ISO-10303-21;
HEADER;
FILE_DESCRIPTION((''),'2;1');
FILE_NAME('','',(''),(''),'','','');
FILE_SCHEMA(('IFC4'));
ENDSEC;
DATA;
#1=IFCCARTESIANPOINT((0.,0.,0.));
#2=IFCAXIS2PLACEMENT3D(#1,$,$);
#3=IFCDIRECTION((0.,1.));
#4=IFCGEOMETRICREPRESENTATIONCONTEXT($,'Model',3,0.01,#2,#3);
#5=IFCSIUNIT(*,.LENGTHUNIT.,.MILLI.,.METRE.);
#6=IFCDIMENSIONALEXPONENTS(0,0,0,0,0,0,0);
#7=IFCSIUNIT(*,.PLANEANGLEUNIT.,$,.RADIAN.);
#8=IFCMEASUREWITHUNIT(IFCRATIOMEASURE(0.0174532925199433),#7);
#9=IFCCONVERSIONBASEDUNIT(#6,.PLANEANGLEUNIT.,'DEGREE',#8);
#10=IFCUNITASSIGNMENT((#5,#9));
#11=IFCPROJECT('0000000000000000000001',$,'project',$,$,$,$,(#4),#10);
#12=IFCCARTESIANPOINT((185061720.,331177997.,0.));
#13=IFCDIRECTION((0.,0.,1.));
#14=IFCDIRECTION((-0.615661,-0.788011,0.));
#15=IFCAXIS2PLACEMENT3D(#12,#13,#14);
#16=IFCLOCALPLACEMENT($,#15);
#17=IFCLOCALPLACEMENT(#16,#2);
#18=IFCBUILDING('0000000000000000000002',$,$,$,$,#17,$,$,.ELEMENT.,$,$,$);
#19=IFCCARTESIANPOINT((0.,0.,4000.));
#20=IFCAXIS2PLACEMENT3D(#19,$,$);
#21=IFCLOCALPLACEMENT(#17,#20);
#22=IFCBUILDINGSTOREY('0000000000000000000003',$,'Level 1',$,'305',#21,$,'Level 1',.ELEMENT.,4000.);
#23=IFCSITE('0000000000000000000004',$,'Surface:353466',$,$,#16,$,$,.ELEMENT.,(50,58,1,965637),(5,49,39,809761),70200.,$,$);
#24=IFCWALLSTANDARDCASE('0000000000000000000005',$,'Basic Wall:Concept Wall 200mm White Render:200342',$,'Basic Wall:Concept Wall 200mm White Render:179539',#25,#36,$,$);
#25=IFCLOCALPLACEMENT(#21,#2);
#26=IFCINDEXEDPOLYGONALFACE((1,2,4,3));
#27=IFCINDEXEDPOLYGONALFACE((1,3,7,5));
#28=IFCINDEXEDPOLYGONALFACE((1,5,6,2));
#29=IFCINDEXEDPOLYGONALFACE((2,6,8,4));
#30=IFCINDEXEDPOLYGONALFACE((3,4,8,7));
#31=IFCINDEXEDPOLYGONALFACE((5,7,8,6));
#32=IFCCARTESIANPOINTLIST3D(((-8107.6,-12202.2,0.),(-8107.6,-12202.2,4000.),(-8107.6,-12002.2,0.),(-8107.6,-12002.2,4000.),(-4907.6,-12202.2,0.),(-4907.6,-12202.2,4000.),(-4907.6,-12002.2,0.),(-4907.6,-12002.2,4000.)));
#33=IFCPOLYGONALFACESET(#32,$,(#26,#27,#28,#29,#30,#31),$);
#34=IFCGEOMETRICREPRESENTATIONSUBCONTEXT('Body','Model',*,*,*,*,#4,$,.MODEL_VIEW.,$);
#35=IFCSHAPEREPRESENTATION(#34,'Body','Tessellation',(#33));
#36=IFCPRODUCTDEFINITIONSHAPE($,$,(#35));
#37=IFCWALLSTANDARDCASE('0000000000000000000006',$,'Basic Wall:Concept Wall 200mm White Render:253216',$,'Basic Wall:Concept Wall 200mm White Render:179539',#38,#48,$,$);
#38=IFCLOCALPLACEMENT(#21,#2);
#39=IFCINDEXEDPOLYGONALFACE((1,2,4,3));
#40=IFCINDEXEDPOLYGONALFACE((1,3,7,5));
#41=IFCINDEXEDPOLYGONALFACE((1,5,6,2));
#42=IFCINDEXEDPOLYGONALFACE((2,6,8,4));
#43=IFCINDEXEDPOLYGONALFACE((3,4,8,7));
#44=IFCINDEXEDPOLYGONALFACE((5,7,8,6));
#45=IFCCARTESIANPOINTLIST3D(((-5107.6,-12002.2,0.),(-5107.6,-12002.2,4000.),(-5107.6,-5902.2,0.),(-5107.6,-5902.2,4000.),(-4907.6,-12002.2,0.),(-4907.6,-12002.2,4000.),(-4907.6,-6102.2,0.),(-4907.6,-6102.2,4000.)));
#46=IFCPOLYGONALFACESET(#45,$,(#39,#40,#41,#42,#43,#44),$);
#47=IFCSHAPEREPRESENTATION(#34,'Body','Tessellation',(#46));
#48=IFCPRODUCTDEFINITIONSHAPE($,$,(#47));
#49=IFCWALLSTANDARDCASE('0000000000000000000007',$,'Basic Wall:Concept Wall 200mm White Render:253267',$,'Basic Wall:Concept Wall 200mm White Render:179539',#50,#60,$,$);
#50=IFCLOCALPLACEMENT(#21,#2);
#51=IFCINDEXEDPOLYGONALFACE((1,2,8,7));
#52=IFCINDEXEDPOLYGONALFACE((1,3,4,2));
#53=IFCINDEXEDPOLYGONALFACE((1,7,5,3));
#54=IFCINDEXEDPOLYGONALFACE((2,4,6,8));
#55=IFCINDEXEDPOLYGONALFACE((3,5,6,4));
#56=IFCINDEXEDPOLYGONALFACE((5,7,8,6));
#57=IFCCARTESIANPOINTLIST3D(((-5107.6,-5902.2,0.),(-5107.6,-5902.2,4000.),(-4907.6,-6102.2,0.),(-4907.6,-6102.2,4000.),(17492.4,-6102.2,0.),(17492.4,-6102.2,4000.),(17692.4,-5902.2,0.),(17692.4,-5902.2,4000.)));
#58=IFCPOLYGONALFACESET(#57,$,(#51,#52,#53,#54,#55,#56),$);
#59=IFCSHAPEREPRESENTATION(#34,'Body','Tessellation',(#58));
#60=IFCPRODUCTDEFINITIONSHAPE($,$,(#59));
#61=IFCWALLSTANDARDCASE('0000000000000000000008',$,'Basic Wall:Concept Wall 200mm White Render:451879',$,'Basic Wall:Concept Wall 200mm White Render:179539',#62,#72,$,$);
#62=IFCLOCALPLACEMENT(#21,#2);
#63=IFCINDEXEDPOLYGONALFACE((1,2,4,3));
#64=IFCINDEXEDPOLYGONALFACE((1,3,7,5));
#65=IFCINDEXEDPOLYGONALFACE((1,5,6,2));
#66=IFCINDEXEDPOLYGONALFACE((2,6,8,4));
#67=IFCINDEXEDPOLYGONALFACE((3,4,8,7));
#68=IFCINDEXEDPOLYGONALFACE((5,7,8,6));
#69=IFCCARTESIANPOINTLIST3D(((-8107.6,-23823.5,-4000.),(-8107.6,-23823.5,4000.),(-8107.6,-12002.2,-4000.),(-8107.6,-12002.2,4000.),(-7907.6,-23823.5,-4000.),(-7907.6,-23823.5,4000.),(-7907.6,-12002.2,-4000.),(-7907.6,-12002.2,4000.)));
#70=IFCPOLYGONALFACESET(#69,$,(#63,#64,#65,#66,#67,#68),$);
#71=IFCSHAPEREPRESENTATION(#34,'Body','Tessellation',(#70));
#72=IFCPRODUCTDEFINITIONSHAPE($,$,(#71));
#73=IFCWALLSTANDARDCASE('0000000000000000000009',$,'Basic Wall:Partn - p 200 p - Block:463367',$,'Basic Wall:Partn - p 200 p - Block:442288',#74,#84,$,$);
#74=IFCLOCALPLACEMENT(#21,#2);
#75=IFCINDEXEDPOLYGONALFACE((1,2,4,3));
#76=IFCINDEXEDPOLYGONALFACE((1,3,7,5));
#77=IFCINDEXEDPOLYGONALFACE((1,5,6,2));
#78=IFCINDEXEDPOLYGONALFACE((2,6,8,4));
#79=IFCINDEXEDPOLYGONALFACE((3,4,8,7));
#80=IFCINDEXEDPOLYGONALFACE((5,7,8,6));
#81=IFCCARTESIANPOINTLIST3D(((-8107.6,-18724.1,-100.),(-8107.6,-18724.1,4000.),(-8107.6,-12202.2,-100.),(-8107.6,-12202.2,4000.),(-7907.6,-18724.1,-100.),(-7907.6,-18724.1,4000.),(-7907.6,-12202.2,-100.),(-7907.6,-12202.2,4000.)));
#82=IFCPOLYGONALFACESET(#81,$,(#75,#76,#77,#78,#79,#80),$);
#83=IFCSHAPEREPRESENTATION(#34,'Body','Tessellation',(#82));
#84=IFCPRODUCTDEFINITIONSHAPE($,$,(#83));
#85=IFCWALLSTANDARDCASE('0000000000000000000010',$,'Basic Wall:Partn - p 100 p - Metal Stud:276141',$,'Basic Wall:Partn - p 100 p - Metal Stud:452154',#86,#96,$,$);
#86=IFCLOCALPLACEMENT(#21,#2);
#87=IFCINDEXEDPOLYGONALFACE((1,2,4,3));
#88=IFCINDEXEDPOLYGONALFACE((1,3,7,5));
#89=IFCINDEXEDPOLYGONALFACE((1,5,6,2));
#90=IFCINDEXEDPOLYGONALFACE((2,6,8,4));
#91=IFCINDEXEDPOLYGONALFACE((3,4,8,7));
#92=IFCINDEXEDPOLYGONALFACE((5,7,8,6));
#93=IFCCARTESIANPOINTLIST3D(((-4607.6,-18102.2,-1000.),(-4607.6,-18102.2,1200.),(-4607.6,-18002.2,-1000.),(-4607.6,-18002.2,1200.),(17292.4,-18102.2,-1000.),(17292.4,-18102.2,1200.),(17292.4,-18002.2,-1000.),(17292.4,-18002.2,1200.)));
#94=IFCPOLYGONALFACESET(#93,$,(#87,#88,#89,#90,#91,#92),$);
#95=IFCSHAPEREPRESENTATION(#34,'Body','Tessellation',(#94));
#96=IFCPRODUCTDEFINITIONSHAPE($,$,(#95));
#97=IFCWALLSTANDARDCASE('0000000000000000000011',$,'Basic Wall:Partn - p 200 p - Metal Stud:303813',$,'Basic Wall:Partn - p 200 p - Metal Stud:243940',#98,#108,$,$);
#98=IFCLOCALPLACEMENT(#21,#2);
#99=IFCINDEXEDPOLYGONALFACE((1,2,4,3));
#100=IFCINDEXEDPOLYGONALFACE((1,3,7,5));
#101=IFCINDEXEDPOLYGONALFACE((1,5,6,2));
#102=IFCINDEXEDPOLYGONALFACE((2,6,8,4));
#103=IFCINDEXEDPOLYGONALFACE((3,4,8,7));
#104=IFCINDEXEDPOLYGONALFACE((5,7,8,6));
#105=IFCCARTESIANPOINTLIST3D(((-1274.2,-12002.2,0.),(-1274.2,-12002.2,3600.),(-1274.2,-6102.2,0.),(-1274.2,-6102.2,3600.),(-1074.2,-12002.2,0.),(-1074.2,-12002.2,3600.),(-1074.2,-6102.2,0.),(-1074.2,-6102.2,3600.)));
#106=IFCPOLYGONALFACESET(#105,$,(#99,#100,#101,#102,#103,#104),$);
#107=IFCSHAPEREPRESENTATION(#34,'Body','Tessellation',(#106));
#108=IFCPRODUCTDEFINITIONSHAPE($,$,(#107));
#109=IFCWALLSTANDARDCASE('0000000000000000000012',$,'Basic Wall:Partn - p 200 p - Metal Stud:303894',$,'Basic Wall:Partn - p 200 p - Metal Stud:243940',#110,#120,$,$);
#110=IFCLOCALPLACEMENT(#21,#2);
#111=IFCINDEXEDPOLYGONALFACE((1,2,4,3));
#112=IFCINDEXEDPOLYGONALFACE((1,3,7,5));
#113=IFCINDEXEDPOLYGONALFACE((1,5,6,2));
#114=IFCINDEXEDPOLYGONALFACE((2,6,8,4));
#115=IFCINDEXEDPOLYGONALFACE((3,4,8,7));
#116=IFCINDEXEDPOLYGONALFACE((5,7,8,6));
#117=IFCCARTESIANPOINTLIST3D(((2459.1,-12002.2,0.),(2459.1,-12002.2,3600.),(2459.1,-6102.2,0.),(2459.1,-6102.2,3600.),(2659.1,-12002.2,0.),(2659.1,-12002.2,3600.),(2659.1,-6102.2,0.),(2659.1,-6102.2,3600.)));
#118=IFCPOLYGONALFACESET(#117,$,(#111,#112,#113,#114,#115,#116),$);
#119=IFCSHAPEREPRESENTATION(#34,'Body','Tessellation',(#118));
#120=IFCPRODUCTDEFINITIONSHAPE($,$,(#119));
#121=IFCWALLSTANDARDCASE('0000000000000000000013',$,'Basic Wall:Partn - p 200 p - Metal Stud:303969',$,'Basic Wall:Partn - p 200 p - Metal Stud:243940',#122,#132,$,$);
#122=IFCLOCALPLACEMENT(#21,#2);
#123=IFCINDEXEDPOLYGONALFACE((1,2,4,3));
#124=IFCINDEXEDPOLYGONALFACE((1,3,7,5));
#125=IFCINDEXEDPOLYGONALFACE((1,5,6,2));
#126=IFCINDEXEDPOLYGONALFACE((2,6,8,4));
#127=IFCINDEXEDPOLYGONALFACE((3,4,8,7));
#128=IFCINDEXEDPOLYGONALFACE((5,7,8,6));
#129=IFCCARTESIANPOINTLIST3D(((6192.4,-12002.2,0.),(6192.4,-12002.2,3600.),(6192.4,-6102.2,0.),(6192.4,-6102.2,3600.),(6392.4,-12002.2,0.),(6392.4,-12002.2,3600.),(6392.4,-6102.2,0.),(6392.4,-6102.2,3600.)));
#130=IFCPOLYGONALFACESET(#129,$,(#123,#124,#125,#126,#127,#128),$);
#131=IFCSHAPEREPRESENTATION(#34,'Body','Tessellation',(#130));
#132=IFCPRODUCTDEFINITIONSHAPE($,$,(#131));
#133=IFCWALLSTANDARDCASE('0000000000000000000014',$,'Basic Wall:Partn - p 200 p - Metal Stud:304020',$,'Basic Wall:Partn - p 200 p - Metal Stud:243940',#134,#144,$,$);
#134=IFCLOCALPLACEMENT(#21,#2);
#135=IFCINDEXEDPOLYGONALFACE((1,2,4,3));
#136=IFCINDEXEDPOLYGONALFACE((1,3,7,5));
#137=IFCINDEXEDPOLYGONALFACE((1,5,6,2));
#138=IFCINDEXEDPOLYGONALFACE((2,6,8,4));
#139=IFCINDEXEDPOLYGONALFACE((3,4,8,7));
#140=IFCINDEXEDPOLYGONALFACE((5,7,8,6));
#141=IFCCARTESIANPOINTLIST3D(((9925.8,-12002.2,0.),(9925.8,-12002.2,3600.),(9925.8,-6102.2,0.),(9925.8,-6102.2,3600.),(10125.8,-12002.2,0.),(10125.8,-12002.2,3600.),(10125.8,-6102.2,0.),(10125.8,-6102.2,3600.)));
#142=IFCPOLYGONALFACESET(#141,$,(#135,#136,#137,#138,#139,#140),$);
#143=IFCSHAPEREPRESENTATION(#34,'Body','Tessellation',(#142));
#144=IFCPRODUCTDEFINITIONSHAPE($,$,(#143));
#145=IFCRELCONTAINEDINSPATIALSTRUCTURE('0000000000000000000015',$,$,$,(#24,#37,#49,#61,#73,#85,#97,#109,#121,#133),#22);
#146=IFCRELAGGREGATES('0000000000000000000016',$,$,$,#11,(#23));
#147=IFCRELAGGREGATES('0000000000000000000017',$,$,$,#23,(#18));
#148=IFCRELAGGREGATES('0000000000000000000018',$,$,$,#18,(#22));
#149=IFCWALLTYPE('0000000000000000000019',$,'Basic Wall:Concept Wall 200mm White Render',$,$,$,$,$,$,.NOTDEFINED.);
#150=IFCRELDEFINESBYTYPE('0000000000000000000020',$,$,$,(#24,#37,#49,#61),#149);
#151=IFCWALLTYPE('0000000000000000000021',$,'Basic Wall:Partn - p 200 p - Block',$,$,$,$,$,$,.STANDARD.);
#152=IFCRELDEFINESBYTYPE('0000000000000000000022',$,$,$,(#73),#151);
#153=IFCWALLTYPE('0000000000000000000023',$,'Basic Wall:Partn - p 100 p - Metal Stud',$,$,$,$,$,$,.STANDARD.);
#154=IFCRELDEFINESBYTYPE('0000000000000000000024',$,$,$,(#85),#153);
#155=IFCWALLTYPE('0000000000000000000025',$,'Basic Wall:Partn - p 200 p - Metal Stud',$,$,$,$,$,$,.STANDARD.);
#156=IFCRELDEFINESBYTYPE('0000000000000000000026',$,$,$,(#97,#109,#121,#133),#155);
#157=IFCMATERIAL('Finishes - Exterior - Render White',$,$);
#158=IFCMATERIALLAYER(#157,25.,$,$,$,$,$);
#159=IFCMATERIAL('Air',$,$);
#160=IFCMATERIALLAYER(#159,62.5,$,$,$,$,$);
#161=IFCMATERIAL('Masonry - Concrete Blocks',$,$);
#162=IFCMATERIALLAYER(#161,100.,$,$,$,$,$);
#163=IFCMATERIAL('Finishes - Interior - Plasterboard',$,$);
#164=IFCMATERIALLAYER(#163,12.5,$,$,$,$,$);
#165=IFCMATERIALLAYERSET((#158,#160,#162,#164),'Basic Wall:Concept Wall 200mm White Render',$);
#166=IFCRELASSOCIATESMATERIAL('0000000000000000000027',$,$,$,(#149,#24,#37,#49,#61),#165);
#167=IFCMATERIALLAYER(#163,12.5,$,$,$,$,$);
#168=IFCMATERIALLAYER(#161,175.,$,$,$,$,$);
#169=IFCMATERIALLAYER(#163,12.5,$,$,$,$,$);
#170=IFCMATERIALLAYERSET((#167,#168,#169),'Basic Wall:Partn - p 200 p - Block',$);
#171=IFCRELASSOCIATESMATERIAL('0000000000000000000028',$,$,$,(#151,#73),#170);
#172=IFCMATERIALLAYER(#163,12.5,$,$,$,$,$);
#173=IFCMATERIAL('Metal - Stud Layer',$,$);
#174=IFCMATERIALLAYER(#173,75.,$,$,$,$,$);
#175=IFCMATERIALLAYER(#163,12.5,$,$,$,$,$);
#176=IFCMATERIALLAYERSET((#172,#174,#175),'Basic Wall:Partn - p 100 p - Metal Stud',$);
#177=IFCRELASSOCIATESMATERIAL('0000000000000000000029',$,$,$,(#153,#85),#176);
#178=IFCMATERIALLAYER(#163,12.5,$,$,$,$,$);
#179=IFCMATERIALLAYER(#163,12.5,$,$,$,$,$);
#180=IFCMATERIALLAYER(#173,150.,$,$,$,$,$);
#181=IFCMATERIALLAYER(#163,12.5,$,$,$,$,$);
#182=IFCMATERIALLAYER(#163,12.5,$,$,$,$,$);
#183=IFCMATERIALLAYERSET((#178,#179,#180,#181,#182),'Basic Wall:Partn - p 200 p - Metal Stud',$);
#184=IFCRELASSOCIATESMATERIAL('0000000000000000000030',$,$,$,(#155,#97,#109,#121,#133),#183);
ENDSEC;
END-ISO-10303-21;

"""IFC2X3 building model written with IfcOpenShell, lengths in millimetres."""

from ifc_helpers import new_model, entity, si_unit, converted_unit, direction, frame, frame_2d, origin, place, context, subcontext, project, spatial, polyline, rectangle, outline, extrude, clip, halfspace, bounded_halfspace, material, layer, layer_set, layer_usage, type_object, element, save


model = new_model("IFC2X3")

# Units and contexts
model_context = context("Model", 3, precision=0.01, world=origin(), true_north=direction((0.0, 1.0)))
body_context = subcontext(model_context, "Body", "Model", "MODEL_VIEW")
ifc_project = project(units=[si_unit("LENGTHUNIT", "METRE", prefix="MILLI"), converted_unit("PLANEANGLEUNIT", "DEGREE", entity("IfcRatioMeasure", 0.0174532925199433), si_unit("PLANEANGLEUNIT", "RADIAN"), dimensions=[0, 0, 0, 0, 0, 0, 0])], contexts=[model_context])

# Site, building, storey
site_placement = place(None, frame((185061720.0, 331177997.0, 0.0), z_axis=(0.0, 0.0, 1.0), x_axis=(-0.615661, -0.788011, 0.0)))
site = spatial("IfcSite", under=ifc_project, at=site_placement, Name="Surface:353466", CompositionType="ELEMENT", RefLatitude=(50, 58, 1, 965637), RefLongitude=(5, 49, 39, 809761), RefElevation=70200.0)
building_placement = place(site_placement, origin())
building = spatial("IfcBuilding", under=site, at=building_placement, CompositionType="ELEMENT")
storey_placement = place(building_placement, frame((0.0, 0.0, 4000.0)))
storey = spatial("IfcBuildingStorey", under=building, at=storey_placement, Name="Level 1", ObjectType="305", LongName="Level 1", CompositionType="ELEMENT", Elevation=4000.0)

# Walls
ifc_material_1 = material(Name="Finishes - Exterior - Render White")
ifc_layer_1 = layer(ifc_material_1, 25.0)
ifc_material_2 = material(Name="Air")
ifc_layer_2 = layer(ifc_material_2, 62.5)
ifc_material_3 = material(Name="Masonry - Concrete Blocks")
ifc_layer_3 = layer(ifc_material_3, 100.0)
ifc_material_4 = material(Name="Finishes - Interior - Plasterboard")
ifc_layer_4 = layer(ifc_material_4, 12.5)
ifc_layer_set_1 = layer_set([ifc_layer_1, ifc_layer_2, ifc_layer_3, ifc_layer_4], Name="Basic Wall:Concept Wall 200mm White Render")
ifc_layer_usage_1 = layer_usage(ifc_layer_set_1, "AXIS2", "NEGATIVE", 100.0)
wall_type_1 = type_object("IfcWallType", Name="Basic Wall:Concept Wall 200mm White Render", PredefinedType="NOTDEFINED", material=ifc_layer_set_1)
wall_1_placement = place(storey_placement, frame((-8107.6, -12102.2, 0.0)))
element("IfcWallStandardCase", 1, at=wall_1_placement, inside=storey, type_object=wall_type_1, material=ifc_layer_usage_1, Name="Basic Wall:Concept Wall 200mm White Render:200342", ObjectType="Basic Wall:Concept Wall 200mm White Render:179539", context=body_context, shape_type="Clipping", body=[
    clip(extrude(rectangle(XDim=3200.0, YDim=200.0, at=frame_2d((1600.0, 0.0), x_axis=(-1.0, 0.0))), origin(), (0.0, 0.0, 1.0), 4000.0), halfspace(frame((0.0, 0.0, -4000.0)), True)),
])
ifc_layer_usage_2 = layer_usage(ifc_layer_set_1, "AXIS2", "NEGATIVE", 100.0)
wall_2_placement = place(storey_placement, frame((-5007.6, -12002.2, 0.0), z_axis=(0.0, 0.0, 1.0), x_axis=(0.0, 1.0, 0.0)))
element("IfcWallStandardCase", 2, at=wall_2_placement, inside=storey, type_object=wall_type_1, material=ifc_layer_usage_2, Name="Basic Wall:Concept Wall 200mm White Render:253216", ObjectType="Basic Wall:Concept Wall 200mm White Render:179539", context=body_context, shape_type="Clipping", body=[
    clip(extrude(outline(polyline([(5900.0, -100.0), (6100.0, 100.0), (0.0, 100.0), (0.0, -100.0), (5900.0, -100.0)])), origin(), (0.0, 0.0, 1.0), 4000.0), halfspace(frame((0.0, 0.0, -4000.0)), True)),
])
ifc_layer_usage_3 = layer_usage(ifc_layer_set_1, "AXIS2", "NEGATIVE", 100.0)
wall_3_placement = place(storey_placement, frame((-5107.6, -6002.2, 0.0)))
element("IfcWallStandardCase", 3, at=wall_3_placement, inside=storey, type_object=wall_type_1, material=ifc_layer_usage_3, Name="Basic Wall:Concept Wall 200mm White Render:253267", ObjectType="Basic Wall:Concept Wall 200mm White Render:179539", context=body_context, shape_type="Clipping", body=[
    clip(extrude(outline(polyline([(200.0, -100.0), (22600.0, -100.0), (22800.0, 100.0), (0.0, 100.0), (200.0, -100.0)])), origin(), (0.0, 0.0, 1.0), 4000.0), halfspace(frame((0.0, 0.0, -4000.0)), True)),
])
ifc_layer_usage_4 = layer_usage(ifc_layer_set_1, "AXIS2", "POSITIVE", -100.0)
wall_4_placement = place(storey_placement, frame((-8007.6, -12002.2, -4000.0), z_axis=(0.0, 0.0, 1.0), x_axis=(0.0, -1.0, 0.0)))
element("IfcWallStandardCase", 4, at=wall_4_placement, inside=storey, type_object=wall_type_1, material=ifc_layer_usage_4, Name="Basic Wall:Concept Wall 200mm White Render:451879", ObjectType="Basic Wall:Concept Wall 200mm White Render:179539", context=body_context, shape_type="Clipping", body=[
    clip(clip(extrude(rectangle(XDim=11821.2, YDim=200.0, at=frame_2d((5910.6, 0.0), x_axis=(-1.0, 0.0))), origin(), (0.0, 0.0, 1.0), 8000.0), halfspace(frame((9000.0, -100.0, 0.0), z_axis=(0.0, 0.0, -1.0), x_axis=(0.0, 1.0, 0.0)), False)), halfspace(frame((0.0, 0.0, -4779.2)), True)),
])
ifc_layer_5 = layer(ifc_material_4, 12.5)
ifc_layer_6 = layer(ifc_material_3, 175.0)
ifc_layer_7 = layer(ifc_material_4, 12.5)
ifc_layer_set_2 = layer_set([ifc_layer_5, ifc_layer_6, ifc_layer_7], Name="Basic Wall:Partn - p 200 p - Block")
ifc_layer_usage_5 = layer_usage(ifc_layer_set_2, "AXIS2", "NEGATIVE", 100.0)
wall_type_2 = type_object("IfcWallType", Name="Basic Wall:Partn - p 200 p - Block", PredefinedType="STANDARD", material=ifc_layer_set_2)
wall_5_placement = place(storey_placement, frame((-8007.6, -18724.1, -100.0), z_axis=(0.0, 0.0, 1.0), x_axis=(0.0, 1.0, 0.0)))
element("IfcWallStandardCase", 5, at=wall_5_placement, inside=storey, type_object=wall_type_2, material=ifc_layer_usage_5, Name="Basic Wall:Partn - p 200 p - Block:463367", ObjectType="Basic Wall:Partn - p 200 p - Block:442288", context=body_context, shape_type="Clipping", body=[
    clip(extrude(rectangle(XDim=6521.9, YDim=200.0, at=frame_2d((3261.0, 0.0), x_axis=(-1.0, 0.0))), origin(), (0.0, 0.0, 1.0), 4100.0), halfspace(frame((0.0, 0.0, -100.0)), True)),
])
ifc_layer_8 = layer(ifc_material_4, 12.5)
ifc_material_5 = material(Name="Metal - Stud Layer")
ifc_layer_9 = layer(ifc_material_5, 75.0)
ifc_layer_10 = layer(ifc_material_4, 12.5)
ifc_layer_set_3 = layer_set([ifc_layer_8, ifc_layer_9, ifc_layer_10], Name="Basic Wall:Partn - p 100 p - Metal Stud")
ifc_layer_usage_6 = layer_usage(ifc_layer_set_3, "AXIS2", "POSITIVE", -50.0)
wall_type_3 = type_object("IfcWallType", Name="Basic Wall:Partn - p 100 p - Metal Stud", PredefinedType="STANDARD", material=ifc_layer_set_3)
wall_6_placement = place(storey_placement, frame((-4607.6, -18052.2, -1000.0)))
element("IfcWallStandardCase", 6, at=wall_6_placement, inside=storey, type_object=wall_type_3, material=ifc_layer_usage_6, Name="Basic Wall:Partn - p 100 p - Metal Stud:276141", ObjectType="Basic Wall:Partn - p 100 p - Metal Stud:452154", context=body_context, shape_type="SweptSolid", body=[
    extrude(rectangle(XDim=21900.0, YDim=100.0, at=frame_2d((10950.0, 0.0), x_axis=(-1.0, 0.0))), origin(), (0.0, 0.0, 1.0), 2200.0),
])
ifc_layer_11 = layer(ifc_material_4, 12.5)
ifc_layer_12 = layer(ifc_material_4, 12.5)
ifc_layer_13 = layer(ifc_material_5, 150.0)
ifc_layer_14 = layer(ifc_material_4, 12.5)
ifc_layer_15 = layer(ifc_material_4, 12.5)
ifc_layer_set_4 = layer_set([ifc_layer_11, ifc_layer_12, ifc_layer_13, ifc_layer_14, ifc_layer_15], Name="Basic Wall:Partn - p 200 p - Metal Stud")
ifc_layer_usage_7 = layer_usage(ifc_layer_set_4, "AXIS2", "NEGATIVE", 100.0)
wall_type_4 = type_object("IfcWallType", Name="Basic Wall:Partn - p 200 p - Metal Stud", PredefinedType="STANDARD", material=ifc_layer_set_4)
wall_7_placement = place(storey_placement, frame((-1174.2, -6102.2, 0.0), z_axis=(0.0, 0.0, 1.0), x_axis=(0.0, -1.0, 0.0)))
element("IfcWallStandardCase", 7, at=wall_7_placement, inside=storey, type_object=wall_type_4, material=ifc_layer_usage_7, Name="Basic Wall:Partn - p 200 p - Metal Stud:303813", ObjectType="Basic Wall:Partn - p 200 p - Metal Stud:243940", context=body_context, shape_type="Clipping", body=[
    clip(extrude(rectangle(XDim=5900.0, YDim=200.0, at=frame_2d((2950.0, 0.0), x_axis=(-1.0, 0.0))), origin(), (0.0, 0.0, 1.0), 3600.0), bounded_halfspace(frame((0.0, -100.0, 3600.0), z_axis=(0.0, 0.0, -1.0), x_axis=(0.0, 1.0, 0.0)), True, frame((0.0, -100.0, 3600.0)), polyline([(0.0, 0.0), (5900.0, 0.0), (5900.0, 200.0), (0.0, 200.0), (0.0, 0.0)]))),
])
ifc_layer_usage_8 = layer_usage(ifc_layer_set_4, "AXIS2", "NEGATIVE", 100.0)
wall_8_placement = place(storey_placement, frame((2559.1, -6102.2, 0.0), z_axis=(0.0, 0.0, 1.0), x_axis=(0.0, -1.0, 0.0)))
element("IfcWallStandardCase", 8, at=wall_8_placement, inside=storey, type_object=wall_type_4, material=ifc_layer_usage_8, Name="Basic Wall:Partn - p 200 p - Metal Stud:303894", ObjectType="Basic Wall:Partn - p 200 p - Metal Stud:243940", context=body_context, shape_type="Clipping", body=[
    clip(extrude(rectangle(XDim=5900.0, YDim=200.0, at=frame_2d((2950.0, 0.0), x_axis=(-1.0, 0.0))), origin(), (0.0, 0.0, 1.0), 3600.0), bounded_halfspace(frame((0.0, -100.0, 3600.0), z_axis=(0.0, 0.0, -1.0), x_axis=(0.0, 1.0, 0.0)), True, frame((0.0, -100.0, 3600.0)), polyline([(0.0, 0.0), (5900.0, 0.0), (5900.0, 200.0), (0.0, 200.0), (0.0, 0.0)]))),
])
ifc_layer_usage_9 = layer_usage(ifc_layer_set_4, "AXIS2", "NEGATIVE", 100.0)
wall_9_placement = place(storey_placement, frame((6292.4, -6102.2, 0.0), z_axis=(0.0, 0.0, 1.0), x_axis=(0.0, -1.0, 0.0)))
element("IfcWallStandardCase", 9, at=wall_9_placement, inside=storey, type_object=wall_type_4, material=ifc_layer_usage_9, Name="Basic Wall:Partn - p 200 p - Metal Stud:303969", ObjectType="Basic Wall:Partn - p 200 p - Metal Stud:243940", context=body_context, shape_type="Clipping", body=[
    clip(extrude(rectangle(XDim=5900.0, YDim=200.0, at=frame_2d((2950.0, 0.0), x_axis=(-1.0, 0.0))), origin(), (0.0, 0.0, 1.0), 3600.0), bounded_halfspace(frame((0.0, -100.0, 3600.0), z_axis=(0.0, 0.0, -1.0), x_axis=(0.0, 1.0, 0.0)), True, frame((0.0, -100.0, 3600.0)), polyline([(0.0, 0.0), (5900.0, 0.0), (5900.0, 200.0), (0.0, 200.0), (0.0, 0.0)]))),
])
ifc_layer_usage_10 = layer_usage(ifc_layer_set_4, "AXIS2", "NEGATIVE", 100.0)
wall_10_placement = place(storey_placement, frame((10025.8, -6102.2, 0.0), z_axis=(0.0, 0.0, 1.0), x_axis=(0.0, -1.0, 0.0)))
element("IfcWallStandardCase", 10, at=wall_10_placement, inside=storey, type_object=wall_type_4, material=ifc_layer_usage_10, Name="Basic Wall:Partn - p 200 p - Metal Stud:304020", ObjectType="Basic Wall:Partn - p 200 p - Metal Stud:243940", context=body_context, shape_type="Clipping", body=[
    clip(extrude(rectangle(XDim=5900.0, YDim=200.0, at=frame_2d((2950.0, 0.0), x_axis=(-1.0, 0.0))), origin(), (0.0, 0.0, 1.0), 3600.0), bounded_halfspace(frame((0.0, -100.0, 3600.0), z_axis=(0.0, 0.0, -1.0), x_axis=(0.0, 1.0, 0.0)), True, frame((0.0, -100.0, 3600.0)), polyline([(0.0, 0.0), (5900.0, 0.0), (5900.0, 200.0), (0.0, 200.0), (0.0, 0.0)]))),
])

save(model, "model.ifc")
